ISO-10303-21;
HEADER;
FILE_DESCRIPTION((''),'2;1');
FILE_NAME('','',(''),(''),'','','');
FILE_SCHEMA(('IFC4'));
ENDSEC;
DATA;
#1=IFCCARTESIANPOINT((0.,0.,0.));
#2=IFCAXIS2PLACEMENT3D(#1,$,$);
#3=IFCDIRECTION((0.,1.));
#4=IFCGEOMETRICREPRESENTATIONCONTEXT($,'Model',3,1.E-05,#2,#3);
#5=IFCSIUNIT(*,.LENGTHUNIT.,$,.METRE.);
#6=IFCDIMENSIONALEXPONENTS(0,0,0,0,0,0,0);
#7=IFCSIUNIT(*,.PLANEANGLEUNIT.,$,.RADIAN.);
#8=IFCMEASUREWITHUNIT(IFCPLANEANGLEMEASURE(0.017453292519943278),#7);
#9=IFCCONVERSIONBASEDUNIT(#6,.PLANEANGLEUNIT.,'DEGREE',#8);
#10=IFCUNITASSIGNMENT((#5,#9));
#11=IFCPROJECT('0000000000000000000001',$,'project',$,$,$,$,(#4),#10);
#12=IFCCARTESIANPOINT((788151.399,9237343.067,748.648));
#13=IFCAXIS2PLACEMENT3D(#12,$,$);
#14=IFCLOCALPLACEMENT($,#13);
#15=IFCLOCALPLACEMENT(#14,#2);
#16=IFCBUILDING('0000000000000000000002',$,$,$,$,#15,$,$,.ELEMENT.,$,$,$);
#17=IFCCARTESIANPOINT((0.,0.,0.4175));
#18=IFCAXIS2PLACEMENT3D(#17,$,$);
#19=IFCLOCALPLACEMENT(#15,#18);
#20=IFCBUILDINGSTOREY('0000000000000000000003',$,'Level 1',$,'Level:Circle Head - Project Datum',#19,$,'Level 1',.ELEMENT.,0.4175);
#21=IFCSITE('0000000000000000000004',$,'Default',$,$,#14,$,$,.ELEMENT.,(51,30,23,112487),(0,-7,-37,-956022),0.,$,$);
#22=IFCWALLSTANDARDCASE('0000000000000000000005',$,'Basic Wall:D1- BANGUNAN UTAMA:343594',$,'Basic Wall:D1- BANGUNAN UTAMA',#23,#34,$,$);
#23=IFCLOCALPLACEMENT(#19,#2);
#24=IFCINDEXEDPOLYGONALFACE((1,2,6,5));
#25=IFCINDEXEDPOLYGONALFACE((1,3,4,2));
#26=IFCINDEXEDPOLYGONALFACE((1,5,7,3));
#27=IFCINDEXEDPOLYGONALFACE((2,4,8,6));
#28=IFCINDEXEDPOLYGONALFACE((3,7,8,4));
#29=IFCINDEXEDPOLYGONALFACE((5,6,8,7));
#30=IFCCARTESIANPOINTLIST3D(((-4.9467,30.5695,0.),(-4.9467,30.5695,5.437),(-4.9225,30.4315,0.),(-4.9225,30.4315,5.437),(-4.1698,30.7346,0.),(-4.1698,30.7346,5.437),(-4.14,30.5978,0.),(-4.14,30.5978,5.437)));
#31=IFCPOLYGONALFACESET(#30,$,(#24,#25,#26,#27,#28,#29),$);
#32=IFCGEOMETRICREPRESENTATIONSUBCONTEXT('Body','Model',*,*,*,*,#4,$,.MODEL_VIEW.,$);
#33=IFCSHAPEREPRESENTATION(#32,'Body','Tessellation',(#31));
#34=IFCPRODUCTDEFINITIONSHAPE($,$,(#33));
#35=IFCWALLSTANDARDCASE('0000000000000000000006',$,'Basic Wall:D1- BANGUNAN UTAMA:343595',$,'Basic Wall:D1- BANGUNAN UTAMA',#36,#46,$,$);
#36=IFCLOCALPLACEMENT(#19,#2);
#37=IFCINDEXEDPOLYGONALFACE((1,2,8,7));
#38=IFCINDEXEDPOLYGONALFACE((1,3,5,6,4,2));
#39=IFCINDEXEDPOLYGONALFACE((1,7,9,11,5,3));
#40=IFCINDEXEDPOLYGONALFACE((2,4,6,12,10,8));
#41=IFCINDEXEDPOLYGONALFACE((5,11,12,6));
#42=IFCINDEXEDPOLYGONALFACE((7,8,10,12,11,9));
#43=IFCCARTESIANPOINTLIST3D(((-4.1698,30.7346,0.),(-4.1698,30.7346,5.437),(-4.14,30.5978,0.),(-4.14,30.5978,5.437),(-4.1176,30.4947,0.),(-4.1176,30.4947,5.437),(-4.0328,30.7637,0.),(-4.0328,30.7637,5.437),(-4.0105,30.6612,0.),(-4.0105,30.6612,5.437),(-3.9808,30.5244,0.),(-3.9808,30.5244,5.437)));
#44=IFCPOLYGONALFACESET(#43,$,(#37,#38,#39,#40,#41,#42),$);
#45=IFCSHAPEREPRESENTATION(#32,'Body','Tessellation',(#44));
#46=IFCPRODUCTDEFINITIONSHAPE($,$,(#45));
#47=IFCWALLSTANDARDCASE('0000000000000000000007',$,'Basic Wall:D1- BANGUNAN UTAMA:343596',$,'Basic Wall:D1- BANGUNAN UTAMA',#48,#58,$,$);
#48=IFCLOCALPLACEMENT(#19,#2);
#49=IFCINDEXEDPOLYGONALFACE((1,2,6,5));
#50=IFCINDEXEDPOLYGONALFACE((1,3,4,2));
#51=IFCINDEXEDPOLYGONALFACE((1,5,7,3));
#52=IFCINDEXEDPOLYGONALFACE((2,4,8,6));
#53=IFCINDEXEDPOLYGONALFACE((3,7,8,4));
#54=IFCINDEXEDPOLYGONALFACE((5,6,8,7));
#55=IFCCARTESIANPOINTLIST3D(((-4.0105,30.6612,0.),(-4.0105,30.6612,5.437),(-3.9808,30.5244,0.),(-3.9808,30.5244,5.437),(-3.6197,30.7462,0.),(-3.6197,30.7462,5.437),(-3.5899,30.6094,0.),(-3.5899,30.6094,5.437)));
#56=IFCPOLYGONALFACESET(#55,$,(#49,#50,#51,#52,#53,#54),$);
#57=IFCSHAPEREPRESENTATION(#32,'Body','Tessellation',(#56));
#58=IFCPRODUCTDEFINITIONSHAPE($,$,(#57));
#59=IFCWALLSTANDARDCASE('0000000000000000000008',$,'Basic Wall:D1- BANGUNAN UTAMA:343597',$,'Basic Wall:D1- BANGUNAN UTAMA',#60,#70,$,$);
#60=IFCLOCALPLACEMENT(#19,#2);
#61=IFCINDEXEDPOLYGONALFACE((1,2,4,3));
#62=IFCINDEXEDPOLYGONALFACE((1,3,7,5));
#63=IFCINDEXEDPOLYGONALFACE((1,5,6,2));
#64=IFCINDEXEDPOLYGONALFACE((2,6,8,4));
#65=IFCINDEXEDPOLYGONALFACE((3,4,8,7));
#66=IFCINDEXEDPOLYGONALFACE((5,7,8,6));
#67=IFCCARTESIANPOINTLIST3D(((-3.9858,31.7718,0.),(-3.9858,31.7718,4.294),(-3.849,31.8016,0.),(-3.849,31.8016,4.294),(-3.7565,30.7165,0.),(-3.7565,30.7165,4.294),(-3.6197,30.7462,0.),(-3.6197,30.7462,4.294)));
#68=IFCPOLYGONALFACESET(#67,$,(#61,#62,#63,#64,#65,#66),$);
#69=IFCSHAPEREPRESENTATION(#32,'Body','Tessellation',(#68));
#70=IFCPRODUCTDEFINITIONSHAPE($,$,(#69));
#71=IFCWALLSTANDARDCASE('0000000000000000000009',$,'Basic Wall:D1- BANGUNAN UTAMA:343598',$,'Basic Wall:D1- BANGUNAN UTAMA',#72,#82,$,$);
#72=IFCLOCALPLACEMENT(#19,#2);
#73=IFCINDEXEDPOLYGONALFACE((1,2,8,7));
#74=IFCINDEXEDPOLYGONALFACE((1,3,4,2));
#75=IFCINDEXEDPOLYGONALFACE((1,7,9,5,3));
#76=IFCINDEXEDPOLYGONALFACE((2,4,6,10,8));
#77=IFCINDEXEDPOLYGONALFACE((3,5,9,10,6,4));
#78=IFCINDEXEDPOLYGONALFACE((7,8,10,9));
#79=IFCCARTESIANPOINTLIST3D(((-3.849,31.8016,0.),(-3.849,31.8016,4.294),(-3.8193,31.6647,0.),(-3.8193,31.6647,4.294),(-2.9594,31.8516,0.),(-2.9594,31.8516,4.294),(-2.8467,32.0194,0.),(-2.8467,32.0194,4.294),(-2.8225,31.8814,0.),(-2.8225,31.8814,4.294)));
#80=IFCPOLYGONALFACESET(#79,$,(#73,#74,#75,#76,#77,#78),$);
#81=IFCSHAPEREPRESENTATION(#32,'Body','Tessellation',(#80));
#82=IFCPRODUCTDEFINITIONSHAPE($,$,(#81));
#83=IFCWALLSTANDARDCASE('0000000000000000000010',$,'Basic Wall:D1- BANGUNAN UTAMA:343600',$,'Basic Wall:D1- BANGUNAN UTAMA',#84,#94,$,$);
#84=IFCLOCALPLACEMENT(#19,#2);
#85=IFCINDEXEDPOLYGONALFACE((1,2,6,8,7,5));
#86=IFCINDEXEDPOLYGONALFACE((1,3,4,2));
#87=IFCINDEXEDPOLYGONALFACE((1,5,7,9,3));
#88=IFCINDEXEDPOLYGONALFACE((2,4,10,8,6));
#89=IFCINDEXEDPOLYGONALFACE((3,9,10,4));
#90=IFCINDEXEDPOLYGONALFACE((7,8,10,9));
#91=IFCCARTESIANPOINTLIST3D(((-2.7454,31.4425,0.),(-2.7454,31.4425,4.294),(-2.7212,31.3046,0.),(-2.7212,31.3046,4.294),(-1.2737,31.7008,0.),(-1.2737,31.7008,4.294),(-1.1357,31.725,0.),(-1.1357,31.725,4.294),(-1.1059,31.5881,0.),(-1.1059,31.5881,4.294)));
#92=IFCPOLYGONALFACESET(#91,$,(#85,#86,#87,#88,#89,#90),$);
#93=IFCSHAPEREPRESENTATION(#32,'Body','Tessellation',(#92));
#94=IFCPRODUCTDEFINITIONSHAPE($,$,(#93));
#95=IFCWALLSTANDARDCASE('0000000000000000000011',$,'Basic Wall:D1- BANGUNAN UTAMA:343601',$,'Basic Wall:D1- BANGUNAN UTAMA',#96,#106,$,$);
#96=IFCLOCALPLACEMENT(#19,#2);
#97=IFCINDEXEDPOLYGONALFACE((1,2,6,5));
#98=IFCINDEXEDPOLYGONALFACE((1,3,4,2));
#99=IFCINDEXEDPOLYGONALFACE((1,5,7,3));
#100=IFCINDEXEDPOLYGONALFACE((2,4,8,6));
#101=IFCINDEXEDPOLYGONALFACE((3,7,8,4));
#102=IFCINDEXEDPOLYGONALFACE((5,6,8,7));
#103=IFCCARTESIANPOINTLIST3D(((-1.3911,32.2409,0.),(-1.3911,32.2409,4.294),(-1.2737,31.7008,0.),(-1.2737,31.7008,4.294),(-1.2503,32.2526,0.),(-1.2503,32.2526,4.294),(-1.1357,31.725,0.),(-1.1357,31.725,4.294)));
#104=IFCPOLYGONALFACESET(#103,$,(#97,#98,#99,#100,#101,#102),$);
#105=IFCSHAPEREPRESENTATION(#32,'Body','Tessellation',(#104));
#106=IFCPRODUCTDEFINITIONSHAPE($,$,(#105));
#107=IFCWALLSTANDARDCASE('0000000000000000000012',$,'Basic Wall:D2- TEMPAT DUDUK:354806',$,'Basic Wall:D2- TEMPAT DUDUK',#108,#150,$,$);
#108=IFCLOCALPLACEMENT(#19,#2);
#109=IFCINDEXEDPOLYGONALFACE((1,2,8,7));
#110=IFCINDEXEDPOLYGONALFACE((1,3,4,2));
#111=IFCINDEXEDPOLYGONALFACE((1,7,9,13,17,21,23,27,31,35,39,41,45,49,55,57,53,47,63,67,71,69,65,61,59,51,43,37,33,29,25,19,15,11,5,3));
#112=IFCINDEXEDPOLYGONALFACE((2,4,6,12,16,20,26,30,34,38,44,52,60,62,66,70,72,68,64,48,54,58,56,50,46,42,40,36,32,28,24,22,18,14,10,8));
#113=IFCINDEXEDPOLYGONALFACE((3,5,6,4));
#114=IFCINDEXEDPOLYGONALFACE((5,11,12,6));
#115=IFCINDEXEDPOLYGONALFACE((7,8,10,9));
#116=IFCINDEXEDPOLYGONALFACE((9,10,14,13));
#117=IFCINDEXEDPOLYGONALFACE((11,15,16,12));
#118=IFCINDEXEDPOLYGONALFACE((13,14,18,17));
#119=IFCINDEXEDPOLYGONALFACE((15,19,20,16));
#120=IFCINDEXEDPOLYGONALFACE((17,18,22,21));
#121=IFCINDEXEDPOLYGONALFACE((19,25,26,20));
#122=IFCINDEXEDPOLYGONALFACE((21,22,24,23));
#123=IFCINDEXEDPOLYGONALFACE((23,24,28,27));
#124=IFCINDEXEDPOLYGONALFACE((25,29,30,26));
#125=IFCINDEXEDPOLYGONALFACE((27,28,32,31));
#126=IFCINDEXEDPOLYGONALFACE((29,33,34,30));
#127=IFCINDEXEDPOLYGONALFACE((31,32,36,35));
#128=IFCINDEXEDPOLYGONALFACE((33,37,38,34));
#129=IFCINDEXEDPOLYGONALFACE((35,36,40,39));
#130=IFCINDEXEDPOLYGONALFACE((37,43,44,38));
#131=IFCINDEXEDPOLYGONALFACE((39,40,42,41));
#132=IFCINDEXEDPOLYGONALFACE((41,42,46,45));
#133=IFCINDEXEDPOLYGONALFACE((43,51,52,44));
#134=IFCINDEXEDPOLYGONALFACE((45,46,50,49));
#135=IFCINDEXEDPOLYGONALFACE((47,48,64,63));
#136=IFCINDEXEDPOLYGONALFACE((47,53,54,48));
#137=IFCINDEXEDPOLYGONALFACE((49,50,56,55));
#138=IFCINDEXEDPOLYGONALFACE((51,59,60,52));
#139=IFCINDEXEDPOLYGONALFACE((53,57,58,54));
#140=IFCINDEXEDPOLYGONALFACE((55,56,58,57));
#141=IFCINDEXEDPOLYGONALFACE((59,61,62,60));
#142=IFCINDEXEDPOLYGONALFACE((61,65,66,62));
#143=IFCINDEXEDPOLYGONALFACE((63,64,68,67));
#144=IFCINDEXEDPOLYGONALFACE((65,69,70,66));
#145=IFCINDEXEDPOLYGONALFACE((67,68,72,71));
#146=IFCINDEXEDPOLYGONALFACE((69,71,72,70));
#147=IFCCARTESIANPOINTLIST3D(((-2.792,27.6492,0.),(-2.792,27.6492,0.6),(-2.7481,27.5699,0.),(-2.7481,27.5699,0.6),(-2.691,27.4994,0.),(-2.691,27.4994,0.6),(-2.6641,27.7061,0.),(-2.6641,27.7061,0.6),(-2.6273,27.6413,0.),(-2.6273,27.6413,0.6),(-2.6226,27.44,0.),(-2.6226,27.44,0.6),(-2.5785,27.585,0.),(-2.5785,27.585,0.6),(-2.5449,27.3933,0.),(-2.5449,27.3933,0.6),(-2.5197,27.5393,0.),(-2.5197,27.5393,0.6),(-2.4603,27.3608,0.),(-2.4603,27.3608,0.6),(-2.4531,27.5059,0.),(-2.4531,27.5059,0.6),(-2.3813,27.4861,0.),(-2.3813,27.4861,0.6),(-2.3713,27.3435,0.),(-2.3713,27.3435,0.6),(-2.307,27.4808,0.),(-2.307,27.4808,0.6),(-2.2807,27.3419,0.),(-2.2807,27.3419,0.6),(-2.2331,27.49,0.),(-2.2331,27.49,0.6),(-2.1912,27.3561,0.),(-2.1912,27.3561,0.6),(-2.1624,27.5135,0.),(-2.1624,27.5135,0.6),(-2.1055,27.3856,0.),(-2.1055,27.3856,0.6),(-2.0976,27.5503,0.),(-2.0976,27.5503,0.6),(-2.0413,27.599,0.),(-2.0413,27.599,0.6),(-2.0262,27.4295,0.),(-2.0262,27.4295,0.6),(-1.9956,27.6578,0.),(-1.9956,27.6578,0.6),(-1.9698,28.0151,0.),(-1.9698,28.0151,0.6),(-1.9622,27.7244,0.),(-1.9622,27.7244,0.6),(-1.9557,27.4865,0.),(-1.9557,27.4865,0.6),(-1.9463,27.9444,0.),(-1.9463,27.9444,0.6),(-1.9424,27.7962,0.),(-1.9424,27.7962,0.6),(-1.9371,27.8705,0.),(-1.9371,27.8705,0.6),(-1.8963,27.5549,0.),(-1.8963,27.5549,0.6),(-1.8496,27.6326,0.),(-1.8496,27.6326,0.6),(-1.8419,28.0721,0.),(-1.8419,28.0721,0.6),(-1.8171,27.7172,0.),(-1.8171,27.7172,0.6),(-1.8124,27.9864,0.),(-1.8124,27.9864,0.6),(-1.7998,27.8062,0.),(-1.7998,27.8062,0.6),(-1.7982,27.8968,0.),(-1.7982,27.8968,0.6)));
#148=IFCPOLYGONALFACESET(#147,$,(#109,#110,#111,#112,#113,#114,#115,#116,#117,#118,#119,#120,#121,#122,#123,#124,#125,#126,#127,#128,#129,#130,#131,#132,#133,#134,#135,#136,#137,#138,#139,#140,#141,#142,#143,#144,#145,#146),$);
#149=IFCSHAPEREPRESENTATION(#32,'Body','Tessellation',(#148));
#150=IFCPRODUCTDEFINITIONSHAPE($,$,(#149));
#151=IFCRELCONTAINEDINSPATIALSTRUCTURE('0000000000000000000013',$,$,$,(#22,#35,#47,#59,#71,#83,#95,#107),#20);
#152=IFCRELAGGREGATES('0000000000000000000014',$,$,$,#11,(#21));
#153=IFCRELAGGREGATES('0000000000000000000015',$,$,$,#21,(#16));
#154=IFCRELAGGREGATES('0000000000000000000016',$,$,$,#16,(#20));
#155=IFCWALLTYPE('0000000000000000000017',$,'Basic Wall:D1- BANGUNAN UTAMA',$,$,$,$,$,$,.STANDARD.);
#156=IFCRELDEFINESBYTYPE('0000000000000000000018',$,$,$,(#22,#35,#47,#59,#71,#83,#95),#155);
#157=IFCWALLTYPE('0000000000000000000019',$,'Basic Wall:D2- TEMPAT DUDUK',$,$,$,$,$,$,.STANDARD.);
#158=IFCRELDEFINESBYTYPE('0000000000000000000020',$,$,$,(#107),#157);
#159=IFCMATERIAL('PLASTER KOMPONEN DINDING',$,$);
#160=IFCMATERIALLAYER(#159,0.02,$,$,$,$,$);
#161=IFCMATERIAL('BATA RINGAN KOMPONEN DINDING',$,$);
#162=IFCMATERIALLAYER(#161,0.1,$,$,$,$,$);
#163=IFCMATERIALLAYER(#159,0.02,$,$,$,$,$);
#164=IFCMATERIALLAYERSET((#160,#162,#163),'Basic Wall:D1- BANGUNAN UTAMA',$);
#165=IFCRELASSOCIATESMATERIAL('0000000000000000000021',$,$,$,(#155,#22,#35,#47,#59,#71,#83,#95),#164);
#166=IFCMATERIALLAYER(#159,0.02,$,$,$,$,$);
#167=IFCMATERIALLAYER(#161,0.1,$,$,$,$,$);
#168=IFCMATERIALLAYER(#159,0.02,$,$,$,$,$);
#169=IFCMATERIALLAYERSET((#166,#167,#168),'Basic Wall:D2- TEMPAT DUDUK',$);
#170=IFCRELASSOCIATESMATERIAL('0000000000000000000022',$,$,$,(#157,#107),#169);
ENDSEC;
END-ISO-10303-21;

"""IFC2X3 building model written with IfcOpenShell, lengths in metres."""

from ifc_helpers import new_model, entity, si_unit, converted_unit, direction, frame, frame_2d, origin, place, context, subcontext, project, spatial, polyline, circle_curve, parameter, trimmed, segment, composite_curve, rectangle, outline, extrude, material, layer, layer_set, layer_usage, type_object, element, save


model = new_model("IFC2X3")

# Units and contexts
model_context = context("Model", 3, precision=1e-05, world=origin(), true_north=direction((0.0, 1.0)))
body_context = subcontext(model_context, "Body", "Model", "MODEL_VIEW")
ifc_project = project(units=[si_unit("LENGTHUNIT", "METRE"), converted_unit("PLANEANGLEUNIT", "DEGREE", entity("IfcPlaneAngleMeasure", 0.017453292519943278), si_unit("PLANEANGLEUNIT", "RADIAN"), dimensions=[0, 0, 0, 0, 0, 0, 0])], contexts=[model_context])

# Site, building, storey
site_placement = place(None, frame((788151.399, 9237343.067, 748.648)))
site = spatial("IfcSite", under=ifc_project, at=site_placement, Name="Default", CompositionType="ELEMENT", RefLatitude=(51, 30, 23, 112487), RefLongitude=(0, -7, -37, -956022), RefElevation=0.0)
building_placement = place(site_placement, origin())
building = spatial("IfcBuilding", under=site, at=building_placement, CompositionType="ELEMENT")
storey_placement = place(building_placement, frame((0.0, 0.0, 0.4175)))
storey = spatial("IfcBuildingStorey", under=building, at=storey_placement, Name="Level 1", ObjectType="Level:Circle Head - Project Datum", LongName="Level 1", CompositionType="ELEMENT", Elevation=0.4175)

# Walls
ifc_material_1 = material(Name="PLASTER KOMPONEN DINDING")
ifc_layer_1 = layer(ifc_material_1, 0.02)
ifc_material_2 = material(Name="BATA RINGAN KOMPONEN DINDING")
ifc_layer_2 = layer(ifc_material_2, 0.1)
ifc_layer_3 = layer(ifc_material_1, 0.02)
ifc_layer_set_1 = layer_set([ifc_layer_1, ifc_layer_2, ifc_layer_3], Name="Basic Wall:D1- BANGUNAN UTAMA")
wall_type_1 = type_object("IfcWallType", Name="Basic Wall:D1- BANGUNAN UTAMA", PredefinedType="STANDARD", material=ifc_layer_set_1)
ifc_layer_usage_1 = layer_usage(ifc_layer_set_1, "AXIS2", "POSITIVE", -0.07)
wall_1_placement = place(storey_placement, frame((-4.937, 30.5, 0.0), z_axis=(0.0, 0.0, 1.0), x_axis=(0.978158, 0.207863, 0.0)))
element("IfcWallStandardCase", 1, at=wall_1_placement, inside=storey, type_object=wall_type_1, material=ifc_layer_usage_1, Name="Basic Wall:D1- BANGUNAN UTAMA:343594", ObjectType="Basic Wall:D1- BANGUNAN UTAMA", context=body_context, shape_type="SweptSolid", body=[
    extrude(outline(polyline([(0.7999, -0.07), (0.7993, 0.07), (0.005, 0.07), (0.0, -0.07), (0.7999, -0.07)])), origin(), (0.0, 0.0, 1.0), 5.437),
])
ifc_layer_usage_2 = layer_usage(ifc_layer_set_1, "AXIS2", "POSITIVE", -0.07)
wall_2_placement = place(storey_placement, frame((-4.1014, 30.7495, 0.0), z_axis=(0.0, 0.0, 1.0), x_axis=(0.212378, -0.977188, 0.0)))
element("IfcWallStandardCase", 2, at=wall_2_placement, inside=storey, type_object=wall_type_1, material=ifc_layer_usage_2, Name="Basic Wall:D1- BANGUNAN UTAMA:343595", ObjectType="Basic Wall:D1- BANGUNAN UTAMA", context=body_context, shape_type="SweptSolid", body=[
    extrude(outline(polyline([(0.2455, -0.07), (0.2455, 0.07), (0.1055, 0.07), (0.0006, 0.07), (0.0, -0.07), (0.14, -0.07), (0.2455, -0.07)])), origin(), (0.0, 0.0, 1.0), 5.437),
])
ifc_layer_usage_3 = layer_usage(ifc_layer_set_1, "AXIS2", "POSITIVE", -0.07)
wall_3_placement = place(storey_placement, frame((-3.9957, 30.5928, 0.0), z_axis=(0.0, 0.0, 1.0), x_axis=(0.977188, 0.212378, 0.0)))
element("IfcWallStandardCase", 3, at=wall_3_placement, inside=storey, type_object=wall_type_1, material=ifc_layer_usage_3, Name="Basic Wall:D1- BANGUNAN UTAMA:343596", ObjectType="Basic Wall:D1- BANGUNAN UTAMA", context=body_context, shape_type="SweptSolid", body=[
    extrude(rectangle(XDim=0.4, YDim=0.14, at=frame_2d((0.2, 0.0), x_axis=(-1.0, 0.0))), origin(), (0.0, 0.0, 1.0), 5.437),
])
ifc_layer_usage_4 = layer_usage(ifc_layer_set_1, "AXIS2", "POSITIVE", -0.07)
wall_4_placement = place(storey_placement, frame((-3.6881, 30.7313, 0.0), z_axis=(0.0, 0.0, 1.0), x_axis=(-0.212378, 0.977188, 0.0)))
element("IfcWallStandardCase", 4, at=wall_4_placement, inside=storey, type_object=wall_type_1, material=ifc_layer_usage_4, Name="Basic Wall:D1- BANGUNAN UTAMA:343597", ObjectType="Basic Wall:D1- BANGUNAN UTAMA", context=body_context, shape_type="SweptSolid", body=[
    extrude(rectangle(XDim=1.08, YDim=0.14, at=frame_2d((0.54, 0.0), x_axis=(-1.0, 0.0))), origin(), (0.0, 0.0, 1.0), 4.294),
])
ifc_layer_usage_5 = layer_usage(ifc_layer_set_1, "AXIS2", "POSITIVE", -0.07)
wall_5_placement = place(storey_placement, frame((-3.8342, 31.7331, 0.0), z_axis=(0.0, 0.0, 1.0), x_axis=(0.977188, 0.212378, 0.0)))
element("IfcWallStandardCase", 5, at=wall_5_placement, inside=storey, type_object=wall_type_1, material=ifc_layer_usage_5, Name="Basic Wall:D1- BANGUNAN UTAMA:343598", ObjectType="Basic Wall:D1- BANGUNAN UTAMA", context=body_context, shape_type="SweptSolid", body=[
    extrude(outline(polyline([(1.0201, -0.07), (1.0258, 0.07), (0.0, 0.07), (0.0, -0.07), (0.88, -0.07), (1.0201, -0.07)])), origin(), (0.0, 0.0, 1.0), 4.294),
])
ifc_layer_usage_6 = layer_usage(ifc_layer_set_1, "AXIS2", "POSITIVE", -0.07)
wall_6_placement = place(storey_placement, frame((-2.7333, 31.3735, 0.0), z_axis=(0.0, 0.0, 1.0), x_axis=(0.984945, 0.172867, 0.0)))
element("IfcWallStandardCase", 6, at=wall_6_placement, inside=storey, type_object=wall_type_1, material=ifc_layer_usage_6, Name="Basic Wall:D1- BANGUNAN UTAMA:343600", ObjectType="Basic Wall:D1- BANGUNAN UTAMA", context=body_context, shape_type="SweptSolid", body=[
    extrude(outline(polyline([(1.64, -0.07), (1.6344, 0.07), (1.4942, 0.07), (0.0, 0.07), (0.0, -0.07), (1.64, -0.07)])), origin(), (0.0, 0.0, 1.0), 4.294),
])
ifc_layer_usage_7 = layer_usage(ifc_layer_set_1, "AXIS2", "POSITIVE", -0.07)
wall_7_placement = place(storey_placement, frame((-1.2041, 31.7101, 0.0), z_axis=(0.0, 0.0, 1.0), x_axis=(-0.212378, 0.977188, 0.0)))
element("IfcWallStandardCase", 7, at=wall_7_placement, inside=storey, type_object=wall_type_1, material=ifc_layer_usage_7, Name="Basic Wall:D1- BANGUNAN UTAMA:343601", ObjectType="Basic Wall:D1- BANGUNAN UTAMA", context=body_context, shape_type="SweptSolid", body=[
    extrude(outline(polyline([(0.5399, -0.07), (0.5583, 0.07), (0.0056, 0.07), (0.0, -0.07), (0.5399, -0.07)])), origin(), (0.0, 0.0, 1.0), 4.294),
])
ifc_layer_4 = layer(ifc_material_1, 0.02)
ifc_layer_5 = layer(ifc_material_2, 0.1)
ifc_layer_6 = layer(ifc_material_1, 0.02)
ifc_layer_set_2 = layer_set([ifc_layer_4, ifc_layer_5, ifc_layer_6], Name="Basic Wall:D2- TEMPAT DUDUK")
ifc_layer_usage_8 = layer_usage(ifc_layer_set_2, "AXIS2", "NEGATIVE", 0.07)
wall_type_2 = type_object("IfcWallType", Name="Basic Wall:D2- TEMPAT DUDUK", PredefinedType="STANDARD", material=ifc_layer_set_2)
wall_8_placement = place(storey_placement, frame((-1.9058, 28.0436, 0.0), z_axis=(0.0, 0.0, 1.0), x_axis=(-0.913586, -0.406645, 0.0)))
element("IfcWallStandardCase", 8, at=wall_8_placement, inside=storey, type_object=wall_type_2, material=ifc_layer_usage_8, Name="Basic Wall:D2- TEMPAT DUDUK:354806", ObjectType="Basic Wall:D2- TEMPAT DUDUK", context=body_context, shape_type="SweptSolid", body=[
    extrude(outline(composite_curve([segment(trimmed(circle_curve(frame_2d((0.45, 0.0), x_axis=(1.0, 0.0)), 0.52), [parameter(0.0)], [parameter(180.0)], True, "PARAMETER"), True, "CONTINUOUS"), segment(polyline([(-0.07, 0.0), (0.07, 0.0)]), True, "CONTINUOUS"), segment(trimmed(circle_curve(frame_2d((0.45, 0.0), x_axis=(1.0, 0.0)), 0.38), [parameter(0.0)], [parameter(180.0)], True, "PARAMETER"), False, "CONTINUOUS"), segment(polyline([(0.83, 0.0), (0.97, 0.0)]), True, "CONTINUOUS")], self_intersect=False)), origin(), (0.0, 0.0, 1.0), 0.6),
])

save(model, "model.ifc")
